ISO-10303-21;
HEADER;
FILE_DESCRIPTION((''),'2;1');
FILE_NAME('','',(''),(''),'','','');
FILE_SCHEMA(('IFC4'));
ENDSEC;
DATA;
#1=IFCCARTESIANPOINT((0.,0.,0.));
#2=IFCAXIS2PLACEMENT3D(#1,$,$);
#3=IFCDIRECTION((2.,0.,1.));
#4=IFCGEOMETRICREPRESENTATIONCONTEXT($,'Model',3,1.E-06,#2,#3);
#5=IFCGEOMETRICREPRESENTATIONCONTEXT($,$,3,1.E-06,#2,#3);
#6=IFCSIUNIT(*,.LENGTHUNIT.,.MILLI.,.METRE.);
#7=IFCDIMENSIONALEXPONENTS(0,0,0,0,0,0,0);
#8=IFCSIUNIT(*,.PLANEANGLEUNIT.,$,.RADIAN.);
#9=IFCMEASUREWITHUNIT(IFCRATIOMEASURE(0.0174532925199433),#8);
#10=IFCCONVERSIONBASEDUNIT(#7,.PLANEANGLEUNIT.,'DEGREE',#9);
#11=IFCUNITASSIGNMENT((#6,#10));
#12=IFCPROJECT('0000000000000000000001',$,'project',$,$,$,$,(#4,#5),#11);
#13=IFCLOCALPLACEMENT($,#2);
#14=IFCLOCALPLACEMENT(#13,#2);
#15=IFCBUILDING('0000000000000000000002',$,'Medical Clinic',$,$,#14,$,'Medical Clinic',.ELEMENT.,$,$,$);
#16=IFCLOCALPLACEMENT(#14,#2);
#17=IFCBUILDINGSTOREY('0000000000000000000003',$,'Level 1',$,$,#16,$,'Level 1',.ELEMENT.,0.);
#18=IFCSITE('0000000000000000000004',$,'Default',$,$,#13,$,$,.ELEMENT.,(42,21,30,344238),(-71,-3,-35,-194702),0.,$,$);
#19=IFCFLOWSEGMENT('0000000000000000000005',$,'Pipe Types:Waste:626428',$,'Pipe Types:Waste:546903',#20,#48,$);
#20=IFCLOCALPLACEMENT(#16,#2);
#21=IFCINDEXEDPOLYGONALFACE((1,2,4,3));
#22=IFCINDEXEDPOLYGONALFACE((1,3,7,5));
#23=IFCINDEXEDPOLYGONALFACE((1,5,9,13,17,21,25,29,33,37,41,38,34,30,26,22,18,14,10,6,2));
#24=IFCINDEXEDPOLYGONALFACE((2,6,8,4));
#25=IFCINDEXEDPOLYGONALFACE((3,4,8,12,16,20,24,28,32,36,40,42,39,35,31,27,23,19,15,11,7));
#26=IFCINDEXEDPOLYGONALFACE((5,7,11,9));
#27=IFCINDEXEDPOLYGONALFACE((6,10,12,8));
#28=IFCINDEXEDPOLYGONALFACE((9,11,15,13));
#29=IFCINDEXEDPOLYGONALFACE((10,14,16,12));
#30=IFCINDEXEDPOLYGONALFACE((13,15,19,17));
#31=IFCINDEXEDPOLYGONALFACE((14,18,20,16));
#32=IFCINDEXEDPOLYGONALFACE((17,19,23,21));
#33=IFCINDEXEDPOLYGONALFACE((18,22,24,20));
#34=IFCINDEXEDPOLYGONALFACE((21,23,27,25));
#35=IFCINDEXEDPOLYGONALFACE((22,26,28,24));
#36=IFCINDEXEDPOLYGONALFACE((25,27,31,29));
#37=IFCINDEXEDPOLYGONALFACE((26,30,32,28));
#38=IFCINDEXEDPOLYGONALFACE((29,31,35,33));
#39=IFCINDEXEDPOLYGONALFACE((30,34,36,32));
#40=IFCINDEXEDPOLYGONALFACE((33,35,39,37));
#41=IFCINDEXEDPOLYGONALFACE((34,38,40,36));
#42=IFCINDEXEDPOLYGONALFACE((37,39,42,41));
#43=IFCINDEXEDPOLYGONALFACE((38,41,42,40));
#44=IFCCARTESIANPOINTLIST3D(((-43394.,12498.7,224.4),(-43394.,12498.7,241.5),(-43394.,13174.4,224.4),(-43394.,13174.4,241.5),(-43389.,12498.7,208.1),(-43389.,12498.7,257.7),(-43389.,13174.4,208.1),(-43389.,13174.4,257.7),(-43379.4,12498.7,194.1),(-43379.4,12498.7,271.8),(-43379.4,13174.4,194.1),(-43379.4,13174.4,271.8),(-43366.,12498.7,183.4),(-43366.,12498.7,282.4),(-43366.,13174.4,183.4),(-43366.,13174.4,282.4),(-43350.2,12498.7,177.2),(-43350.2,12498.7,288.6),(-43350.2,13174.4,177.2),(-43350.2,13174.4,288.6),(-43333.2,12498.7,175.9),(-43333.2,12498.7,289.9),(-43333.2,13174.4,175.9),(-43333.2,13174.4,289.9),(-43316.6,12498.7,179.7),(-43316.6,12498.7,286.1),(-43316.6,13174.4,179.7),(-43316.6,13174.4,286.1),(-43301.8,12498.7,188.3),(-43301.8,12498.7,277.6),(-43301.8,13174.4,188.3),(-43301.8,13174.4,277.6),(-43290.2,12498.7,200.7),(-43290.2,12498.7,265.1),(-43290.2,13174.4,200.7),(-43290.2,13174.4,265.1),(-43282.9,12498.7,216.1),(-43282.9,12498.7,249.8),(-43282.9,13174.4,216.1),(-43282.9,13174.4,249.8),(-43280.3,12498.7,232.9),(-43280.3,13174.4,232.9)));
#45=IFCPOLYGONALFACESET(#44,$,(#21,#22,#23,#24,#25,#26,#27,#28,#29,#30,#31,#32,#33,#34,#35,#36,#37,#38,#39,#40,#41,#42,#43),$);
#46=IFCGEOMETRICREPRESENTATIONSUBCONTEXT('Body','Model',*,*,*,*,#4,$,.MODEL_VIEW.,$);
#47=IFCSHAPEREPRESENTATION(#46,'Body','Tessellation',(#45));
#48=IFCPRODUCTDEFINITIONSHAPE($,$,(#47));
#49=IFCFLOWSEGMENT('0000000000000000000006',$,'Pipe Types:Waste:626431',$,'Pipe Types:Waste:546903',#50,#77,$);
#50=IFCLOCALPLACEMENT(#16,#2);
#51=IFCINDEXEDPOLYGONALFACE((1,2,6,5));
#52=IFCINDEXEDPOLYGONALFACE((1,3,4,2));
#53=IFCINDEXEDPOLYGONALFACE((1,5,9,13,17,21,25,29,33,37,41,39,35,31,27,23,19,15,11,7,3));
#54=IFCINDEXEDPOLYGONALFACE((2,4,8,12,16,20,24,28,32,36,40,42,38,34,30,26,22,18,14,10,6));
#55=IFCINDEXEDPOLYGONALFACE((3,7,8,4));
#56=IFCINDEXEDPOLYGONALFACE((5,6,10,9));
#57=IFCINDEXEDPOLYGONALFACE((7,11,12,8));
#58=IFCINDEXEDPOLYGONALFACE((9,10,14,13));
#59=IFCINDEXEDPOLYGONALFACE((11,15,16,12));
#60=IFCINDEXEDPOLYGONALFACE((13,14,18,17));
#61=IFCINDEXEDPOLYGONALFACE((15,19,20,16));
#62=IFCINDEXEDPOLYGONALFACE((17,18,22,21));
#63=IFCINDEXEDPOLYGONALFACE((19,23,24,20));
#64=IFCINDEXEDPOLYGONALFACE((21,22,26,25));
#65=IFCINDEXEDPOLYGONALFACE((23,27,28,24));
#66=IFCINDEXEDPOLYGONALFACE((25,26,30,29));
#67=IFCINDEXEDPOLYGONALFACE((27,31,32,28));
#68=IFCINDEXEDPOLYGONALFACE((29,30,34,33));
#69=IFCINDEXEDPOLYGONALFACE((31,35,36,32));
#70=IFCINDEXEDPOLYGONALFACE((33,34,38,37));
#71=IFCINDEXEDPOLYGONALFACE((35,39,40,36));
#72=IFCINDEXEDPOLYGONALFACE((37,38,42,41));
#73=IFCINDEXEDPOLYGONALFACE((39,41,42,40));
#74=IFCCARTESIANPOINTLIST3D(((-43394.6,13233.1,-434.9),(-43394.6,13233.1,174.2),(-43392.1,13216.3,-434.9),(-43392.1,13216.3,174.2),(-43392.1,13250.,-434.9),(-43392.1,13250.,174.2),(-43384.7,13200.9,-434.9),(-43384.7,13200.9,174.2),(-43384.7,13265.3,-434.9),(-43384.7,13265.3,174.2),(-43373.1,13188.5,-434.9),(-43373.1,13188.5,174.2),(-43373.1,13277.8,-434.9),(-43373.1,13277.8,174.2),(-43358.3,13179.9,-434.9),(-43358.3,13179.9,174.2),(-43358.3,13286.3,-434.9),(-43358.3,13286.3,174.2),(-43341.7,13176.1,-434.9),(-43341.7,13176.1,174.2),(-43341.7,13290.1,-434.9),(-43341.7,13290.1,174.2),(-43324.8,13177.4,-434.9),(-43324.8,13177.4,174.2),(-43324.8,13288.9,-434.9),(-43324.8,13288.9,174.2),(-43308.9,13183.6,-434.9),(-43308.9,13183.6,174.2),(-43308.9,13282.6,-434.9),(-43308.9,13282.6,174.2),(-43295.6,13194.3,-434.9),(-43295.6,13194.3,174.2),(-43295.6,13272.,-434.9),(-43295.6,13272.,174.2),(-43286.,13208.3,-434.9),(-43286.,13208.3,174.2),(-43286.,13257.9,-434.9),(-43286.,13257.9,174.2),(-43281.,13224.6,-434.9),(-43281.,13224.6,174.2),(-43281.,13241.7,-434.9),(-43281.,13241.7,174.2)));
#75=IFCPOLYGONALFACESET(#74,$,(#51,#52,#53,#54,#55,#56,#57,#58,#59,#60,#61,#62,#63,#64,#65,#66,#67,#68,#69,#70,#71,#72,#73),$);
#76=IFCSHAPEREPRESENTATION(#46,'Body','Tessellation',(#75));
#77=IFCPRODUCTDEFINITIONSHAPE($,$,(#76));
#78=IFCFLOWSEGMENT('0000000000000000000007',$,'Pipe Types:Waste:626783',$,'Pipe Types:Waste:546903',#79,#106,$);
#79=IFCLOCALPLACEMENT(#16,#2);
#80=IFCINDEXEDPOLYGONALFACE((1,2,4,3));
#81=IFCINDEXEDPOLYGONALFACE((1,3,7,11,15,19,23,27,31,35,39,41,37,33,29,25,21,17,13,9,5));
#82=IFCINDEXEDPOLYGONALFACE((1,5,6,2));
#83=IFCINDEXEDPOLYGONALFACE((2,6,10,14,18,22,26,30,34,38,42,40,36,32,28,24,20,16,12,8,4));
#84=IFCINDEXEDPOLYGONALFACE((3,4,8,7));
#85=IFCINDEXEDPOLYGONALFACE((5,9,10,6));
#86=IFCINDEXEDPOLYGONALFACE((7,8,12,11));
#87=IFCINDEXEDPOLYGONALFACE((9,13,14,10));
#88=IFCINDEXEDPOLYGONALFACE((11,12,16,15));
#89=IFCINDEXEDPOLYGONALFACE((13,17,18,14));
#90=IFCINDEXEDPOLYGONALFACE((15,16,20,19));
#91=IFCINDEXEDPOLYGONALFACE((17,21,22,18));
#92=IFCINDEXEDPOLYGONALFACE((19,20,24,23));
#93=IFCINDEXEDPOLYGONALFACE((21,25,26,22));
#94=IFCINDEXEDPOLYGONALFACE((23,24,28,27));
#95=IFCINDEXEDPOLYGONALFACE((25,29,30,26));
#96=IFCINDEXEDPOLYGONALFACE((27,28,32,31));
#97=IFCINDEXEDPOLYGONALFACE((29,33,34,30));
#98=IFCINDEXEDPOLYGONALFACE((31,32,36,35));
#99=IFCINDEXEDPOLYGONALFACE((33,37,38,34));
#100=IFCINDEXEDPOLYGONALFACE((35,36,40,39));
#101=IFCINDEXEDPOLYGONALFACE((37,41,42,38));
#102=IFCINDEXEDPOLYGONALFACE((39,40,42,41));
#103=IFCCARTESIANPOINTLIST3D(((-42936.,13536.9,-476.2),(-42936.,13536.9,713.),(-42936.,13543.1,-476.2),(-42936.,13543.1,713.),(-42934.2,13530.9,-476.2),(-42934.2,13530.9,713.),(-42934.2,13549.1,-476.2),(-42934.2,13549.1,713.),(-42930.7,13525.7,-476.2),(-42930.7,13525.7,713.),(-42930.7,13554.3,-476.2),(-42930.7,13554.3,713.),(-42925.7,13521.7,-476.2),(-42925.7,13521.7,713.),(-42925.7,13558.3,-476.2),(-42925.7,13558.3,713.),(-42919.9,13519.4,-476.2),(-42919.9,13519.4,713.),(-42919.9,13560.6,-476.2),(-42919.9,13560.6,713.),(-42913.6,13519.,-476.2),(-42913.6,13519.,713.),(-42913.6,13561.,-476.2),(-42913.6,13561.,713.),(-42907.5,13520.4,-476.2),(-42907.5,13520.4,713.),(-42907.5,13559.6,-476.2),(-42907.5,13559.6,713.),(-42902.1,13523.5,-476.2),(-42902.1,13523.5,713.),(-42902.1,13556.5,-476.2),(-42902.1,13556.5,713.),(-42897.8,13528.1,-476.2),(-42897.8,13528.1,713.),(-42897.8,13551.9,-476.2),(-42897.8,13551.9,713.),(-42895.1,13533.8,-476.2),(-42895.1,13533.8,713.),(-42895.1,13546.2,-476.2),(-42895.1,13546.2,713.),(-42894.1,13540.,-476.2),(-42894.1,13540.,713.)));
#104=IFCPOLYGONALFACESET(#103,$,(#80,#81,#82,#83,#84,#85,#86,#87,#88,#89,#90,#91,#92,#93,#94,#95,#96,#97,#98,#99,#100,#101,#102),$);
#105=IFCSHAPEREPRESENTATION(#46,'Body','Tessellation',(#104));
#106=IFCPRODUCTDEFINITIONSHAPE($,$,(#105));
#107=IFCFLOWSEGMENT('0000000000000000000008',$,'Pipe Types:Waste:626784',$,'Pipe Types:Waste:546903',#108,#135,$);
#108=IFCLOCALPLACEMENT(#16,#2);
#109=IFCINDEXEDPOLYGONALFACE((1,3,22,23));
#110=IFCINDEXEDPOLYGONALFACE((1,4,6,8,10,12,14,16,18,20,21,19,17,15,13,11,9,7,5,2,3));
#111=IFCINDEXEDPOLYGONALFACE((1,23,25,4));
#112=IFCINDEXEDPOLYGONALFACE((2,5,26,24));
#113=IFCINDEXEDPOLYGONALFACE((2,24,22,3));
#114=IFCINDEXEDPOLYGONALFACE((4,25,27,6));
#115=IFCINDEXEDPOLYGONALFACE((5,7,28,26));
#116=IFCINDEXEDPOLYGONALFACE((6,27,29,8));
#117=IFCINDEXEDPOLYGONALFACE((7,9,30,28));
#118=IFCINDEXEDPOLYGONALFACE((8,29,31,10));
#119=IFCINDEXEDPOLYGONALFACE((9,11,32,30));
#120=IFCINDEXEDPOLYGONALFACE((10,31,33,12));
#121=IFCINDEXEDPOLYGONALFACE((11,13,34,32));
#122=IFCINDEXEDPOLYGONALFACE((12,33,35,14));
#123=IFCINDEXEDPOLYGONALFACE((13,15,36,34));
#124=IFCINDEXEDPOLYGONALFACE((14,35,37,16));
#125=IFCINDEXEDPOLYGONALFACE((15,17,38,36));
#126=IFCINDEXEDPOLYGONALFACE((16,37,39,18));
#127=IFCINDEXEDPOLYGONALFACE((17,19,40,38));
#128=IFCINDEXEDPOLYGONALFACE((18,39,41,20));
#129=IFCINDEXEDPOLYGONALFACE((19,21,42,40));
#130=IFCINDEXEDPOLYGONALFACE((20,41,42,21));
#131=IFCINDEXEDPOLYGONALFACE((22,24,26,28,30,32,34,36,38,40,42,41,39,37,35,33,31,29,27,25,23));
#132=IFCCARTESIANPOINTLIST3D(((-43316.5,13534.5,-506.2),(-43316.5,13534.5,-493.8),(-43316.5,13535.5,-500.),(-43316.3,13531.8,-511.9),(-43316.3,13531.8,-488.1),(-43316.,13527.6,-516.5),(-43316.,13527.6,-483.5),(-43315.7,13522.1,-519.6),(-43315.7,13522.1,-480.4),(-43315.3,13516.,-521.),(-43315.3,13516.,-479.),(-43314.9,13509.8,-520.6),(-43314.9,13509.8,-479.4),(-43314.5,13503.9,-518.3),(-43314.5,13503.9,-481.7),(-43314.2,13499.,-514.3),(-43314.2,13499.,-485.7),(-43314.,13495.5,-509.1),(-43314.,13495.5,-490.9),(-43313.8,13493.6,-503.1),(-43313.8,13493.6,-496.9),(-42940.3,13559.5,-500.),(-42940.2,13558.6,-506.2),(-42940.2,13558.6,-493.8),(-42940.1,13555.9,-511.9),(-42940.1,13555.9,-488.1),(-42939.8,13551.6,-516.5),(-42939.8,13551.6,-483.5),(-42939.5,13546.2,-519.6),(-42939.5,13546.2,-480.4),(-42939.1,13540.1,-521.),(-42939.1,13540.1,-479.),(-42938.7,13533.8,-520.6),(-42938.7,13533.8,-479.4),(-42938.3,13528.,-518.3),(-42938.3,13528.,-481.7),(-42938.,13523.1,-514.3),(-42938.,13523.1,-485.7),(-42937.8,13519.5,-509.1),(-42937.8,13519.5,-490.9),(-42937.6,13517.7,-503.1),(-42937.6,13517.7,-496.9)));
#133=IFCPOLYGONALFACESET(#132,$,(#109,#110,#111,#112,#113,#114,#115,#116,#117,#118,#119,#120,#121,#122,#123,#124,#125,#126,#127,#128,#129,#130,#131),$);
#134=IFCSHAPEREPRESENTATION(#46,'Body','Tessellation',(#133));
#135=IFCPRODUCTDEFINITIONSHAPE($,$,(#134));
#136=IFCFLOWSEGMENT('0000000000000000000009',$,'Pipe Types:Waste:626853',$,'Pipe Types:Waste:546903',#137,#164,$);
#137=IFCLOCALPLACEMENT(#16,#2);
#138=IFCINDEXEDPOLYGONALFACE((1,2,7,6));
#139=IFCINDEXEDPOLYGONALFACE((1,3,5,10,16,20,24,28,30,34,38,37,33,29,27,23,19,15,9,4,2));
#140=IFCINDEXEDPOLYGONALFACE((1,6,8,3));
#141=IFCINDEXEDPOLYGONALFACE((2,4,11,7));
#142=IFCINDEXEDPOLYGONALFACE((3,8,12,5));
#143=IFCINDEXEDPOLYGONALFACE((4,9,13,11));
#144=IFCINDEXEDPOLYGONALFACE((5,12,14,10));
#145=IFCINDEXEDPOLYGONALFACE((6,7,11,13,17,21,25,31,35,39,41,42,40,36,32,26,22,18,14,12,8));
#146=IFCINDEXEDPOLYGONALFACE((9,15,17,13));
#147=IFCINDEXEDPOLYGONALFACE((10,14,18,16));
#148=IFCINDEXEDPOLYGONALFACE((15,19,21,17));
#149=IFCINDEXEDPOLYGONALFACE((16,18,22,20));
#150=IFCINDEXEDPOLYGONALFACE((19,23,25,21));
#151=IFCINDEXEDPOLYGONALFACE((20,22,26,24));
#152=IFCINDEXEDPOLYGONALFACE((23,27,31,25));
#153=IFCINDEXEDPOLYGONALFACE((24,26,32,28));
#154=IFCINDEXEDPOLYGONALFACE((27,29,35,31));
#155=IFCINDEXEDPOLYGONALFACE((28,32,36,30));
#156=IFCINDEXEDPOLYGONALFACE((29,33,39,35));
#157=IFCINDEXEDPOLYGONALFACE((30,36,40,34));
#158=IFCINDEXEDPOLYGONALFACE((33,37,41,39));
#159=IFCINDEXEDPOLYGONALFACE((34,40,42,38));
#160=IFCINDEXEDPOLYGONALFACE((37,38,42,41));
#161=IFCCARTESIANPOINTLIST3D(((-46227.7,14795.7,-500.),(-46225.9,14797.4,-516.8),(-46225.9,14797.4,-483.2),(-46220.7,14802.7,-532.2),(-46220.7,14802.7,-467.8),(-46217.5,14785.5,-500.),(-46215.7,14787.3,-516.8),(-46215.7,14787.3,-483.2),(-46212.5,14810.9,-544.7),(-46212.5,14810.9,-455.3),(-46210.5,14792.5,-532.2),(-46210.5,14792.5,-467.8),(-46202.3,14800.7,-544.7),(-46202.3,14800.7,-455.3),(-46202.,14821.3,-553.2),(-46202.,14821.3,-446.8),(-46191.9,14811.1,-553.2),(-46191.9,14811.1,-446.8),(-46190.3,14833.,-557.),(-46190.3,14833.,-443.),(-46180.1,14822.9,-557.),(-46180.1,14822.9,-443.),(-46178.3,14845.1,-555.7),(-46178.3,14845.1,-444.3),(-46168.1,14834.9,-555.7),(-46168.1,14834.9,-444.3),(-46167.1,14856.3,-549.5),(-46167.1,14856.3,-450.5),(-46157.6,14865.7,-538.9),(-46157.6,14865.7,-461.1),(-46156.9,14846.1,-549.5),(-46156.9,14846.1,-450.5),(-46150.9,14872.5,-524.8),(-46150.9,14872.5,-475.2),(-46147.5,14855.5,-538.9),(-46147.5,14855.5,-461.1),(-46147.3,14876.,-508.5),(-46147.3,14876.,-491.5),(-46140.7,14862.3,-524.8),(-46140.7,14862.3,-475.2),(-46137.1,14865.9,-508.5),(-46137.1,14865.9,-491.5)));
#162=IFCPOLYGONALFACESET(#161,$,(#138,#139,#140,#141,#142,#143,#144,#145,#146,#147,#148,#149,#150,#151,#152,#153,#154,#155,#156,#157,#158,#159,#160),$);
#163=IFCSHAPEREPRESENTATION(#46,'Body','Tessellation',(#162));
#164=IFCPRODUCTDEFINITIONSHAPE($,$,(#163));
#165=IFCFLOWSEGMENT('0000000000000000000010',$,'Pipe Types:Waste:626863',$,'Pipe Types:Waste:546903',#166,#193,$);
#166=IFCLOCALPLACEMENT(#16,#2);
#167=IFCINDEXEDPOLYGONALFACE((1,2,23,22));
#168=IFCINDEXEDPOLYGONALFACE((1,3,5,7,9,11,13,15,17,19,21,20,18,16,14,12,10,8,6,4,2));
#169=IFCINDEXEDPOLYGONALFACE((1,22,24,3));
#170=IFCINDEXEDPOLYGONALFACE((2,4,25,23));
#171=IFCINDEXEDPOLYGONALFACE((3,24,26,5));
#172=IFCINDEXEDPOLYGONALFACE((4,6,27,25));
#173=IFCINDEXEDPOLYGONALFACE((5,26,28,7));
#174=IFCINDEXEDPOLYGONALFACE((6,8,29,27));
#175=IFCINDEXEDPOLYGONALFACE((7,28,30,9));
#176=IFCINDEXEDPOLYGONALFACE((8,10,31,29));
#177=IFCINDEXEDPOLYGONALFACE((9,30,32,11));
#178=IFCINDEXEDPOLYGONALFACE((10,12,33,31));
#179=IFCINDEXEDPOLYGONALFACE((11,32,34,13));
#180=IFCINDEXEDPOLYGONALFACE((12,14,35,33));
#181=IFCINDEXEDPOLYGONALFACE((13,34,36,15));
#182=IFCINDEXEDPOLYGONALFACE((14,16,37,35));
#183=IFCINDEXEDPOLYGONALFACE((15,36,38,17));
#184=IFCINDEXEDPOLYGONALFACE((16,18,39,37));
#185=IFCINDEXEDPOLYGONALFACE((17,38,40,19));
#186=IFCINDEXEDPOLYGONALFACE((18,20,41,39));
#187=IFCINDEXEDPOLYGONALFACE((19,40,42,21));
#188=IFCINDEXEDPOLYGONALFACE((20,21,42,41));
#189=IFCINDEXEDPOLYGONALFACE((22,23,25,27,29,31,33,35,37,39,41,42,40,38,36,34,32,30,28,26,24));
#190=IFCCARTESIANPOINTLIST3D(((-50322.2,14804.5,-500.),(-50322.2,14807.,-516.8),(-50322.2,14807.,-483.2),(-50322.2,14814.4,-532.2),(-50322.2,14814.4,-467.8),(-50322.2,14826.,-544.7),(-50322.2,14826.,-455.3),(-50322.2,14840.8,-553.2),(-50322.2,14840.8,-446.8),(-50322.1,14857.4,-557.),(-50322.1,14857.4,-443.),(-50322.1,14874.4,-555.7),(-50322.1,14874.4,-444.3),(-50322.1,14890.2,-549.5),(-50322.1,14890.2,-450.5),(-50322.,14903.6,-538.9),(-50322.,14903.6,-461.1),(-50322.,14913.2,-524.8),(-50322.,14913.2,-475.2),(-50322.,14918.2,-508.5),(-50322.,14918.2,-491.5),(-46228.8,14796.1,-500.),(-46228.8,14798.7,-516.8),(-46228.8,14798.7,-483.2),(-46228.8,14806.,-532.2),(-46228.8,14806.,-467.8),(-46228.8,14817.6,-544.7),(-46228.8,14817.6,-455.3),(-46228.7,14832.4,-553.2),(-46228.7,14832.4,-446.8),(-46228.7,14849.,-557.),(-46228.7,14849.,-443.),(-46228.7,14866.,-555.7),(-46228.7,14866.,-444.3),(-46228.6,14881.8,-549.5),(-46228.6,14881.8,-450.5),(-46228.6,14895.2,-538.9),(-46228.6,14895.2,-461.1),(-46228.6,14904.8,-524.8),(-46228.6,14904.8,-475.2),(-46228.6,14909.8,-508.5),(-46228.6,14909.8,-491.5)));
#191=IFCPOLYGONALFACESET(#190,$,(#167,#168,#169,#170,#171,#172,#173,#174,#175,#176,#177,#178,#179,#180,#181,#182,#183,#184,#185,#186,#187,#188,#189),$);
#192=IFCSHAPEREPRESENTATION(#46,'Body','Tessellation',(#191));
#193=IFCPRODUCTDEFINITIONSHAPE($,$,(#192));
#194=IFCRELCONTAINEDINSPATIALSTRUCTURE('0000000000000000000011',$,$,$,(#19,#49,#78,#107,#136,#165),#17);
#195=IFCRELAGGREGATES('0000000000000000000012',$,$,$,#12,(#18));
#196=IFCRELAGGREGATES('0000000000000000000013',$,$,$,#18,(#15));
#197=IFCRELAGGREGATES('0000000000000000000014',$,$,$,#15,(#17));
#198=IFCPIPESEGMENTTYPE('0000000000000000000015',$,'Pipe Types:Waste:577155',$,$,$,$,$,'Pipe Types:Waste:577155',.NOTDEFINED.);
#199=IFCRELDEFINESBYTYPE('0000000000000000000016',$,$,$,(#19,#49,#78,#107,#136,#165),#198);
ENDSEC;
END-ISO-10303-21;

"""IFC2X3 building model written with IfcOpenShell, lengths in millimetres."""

from ifc_helpers import new_model, entity, si_unit, converted_unit, direction, frame, frame_2d, origin, origin_2d_with_axis, place, context, subcontext, project, spatial, circle, extrude, type_object, element, save


model = new_model("IFC2X3")

# Units and contexts
model_context = context("Model", 3, precision=1e-06, world=origin(), true_north=direction((2.0, 0.0, 1.0)))
context_of_model = context(None, 3, precision=1e-06, world=origin(), true_north=direction((2.0, 0.0, 1.0)))
body_context = subcontext(model_context, "Body", "Model", "MODEL_VIEW")
ifc_project = project(units=[si_unit("LENGTHUNIT", "METRE", prefix="MILLI"), converted_unit("PLANEANGLEUNIT", "DEGREE", entity("IfcRatioMeasure", 0.0174532925199433), si_unit("PLANEANGLEUNIT", "RADIAN"), dimensions=[0, 0, 0, 0, 0, 0, 0])], contexts=[model_context, context_of_model])

# Site, building, storey
site_placement = place(None, origin())
site = spatial("IfcSite", under=ifc_project, at=site_placement, Name="Default", CompositionType="ELEMENT", RefLatitude=(42, 21, 30, 344238), RefLongitude=(-71, -3, -35, -194702), RefElevation=0.0)
building_placement = place(site_placement, origin())
building = spatial("IfcBuilding", under=site, at=building_placement, Name="Medical Clinic", LongName="Medical Clinic", CompositionType="ELEMENT")
storey_placement = place(building_placement, origin())
storey = spatial("IfcBuildingStorey", under=building, at=storey_placement, Name="Level 1", LongName="Level 1", CompositionType="ELEMENT", Elevation=0.0)

# Flow segments
pipe_segment_type = type_object("IfcPipeSegmentType", Name="Pipe Types:Waste:577155", ElementType="Pipe Types:Waste:577155", PredefinedType="NOTDEFINED")
flow_segment_1_placement = place(storey_placement, origin())
element("IfcFlowSegment", 1, at=flow_segment_1_placement, inside=storey, type_object=pipe_segment_type, Name="Pipe Types:Waste:626428", ObjectType="Pipe Types:Waste:546903", context=body_context, shape_type="SweptSolid", body=[
    extrude(circle(Radius=57.1, at=frame_2d((0.0, 0.0), x_axis=(1.0, 0.0))), frame((-43337.5, 12498.7, 232.9), z_axis=(0.0, 1.0, 0.0), x_axis=(1.0, 0.0, 0.0)), (0.0, 0.0, 1.0), 675.7),
])
flow_segment_2_placement = place(storey_placement, origin())
element("IfcFlowSegment", 2, at=flow_segment_2_placement, inside=storey, type_object=pipe_segment_type, Name="Pipe Types:Waste:626431", ObjectType="Pipe Types:Waste:546903", context=body_context, shape_type="SweptSolid", body=[
    extrude(circle(Radius=57.1, at=origin_2d_with_axis()), frame((-43337.5, 13233.1, -434.9), z_axis=(0.0, 0.0, 1.0), x_axis=(-1.0, 0.0, 0.0)), (0.0, 0.0, 1.0), 609.1),
])
flow_segment_3_placement = place(storey_placement, origin())
element("IfcFlowSegment", 3, at=flow_segment_3_placement, inside=storey, type_object=pipe_segment_type, Name="Pipe Types:Waste:626783", ObjectType="Pipe Types:Waste:546903", context=body_context, shape_type="SweptSolid", body=[
    extrude(circle(Radius=21.1, at=frame_2d((0.0, 0.0), x_axis=(1.0, 0.0))), frame((-42915.2, 13540.0, -476.2)), (0.0, 0.0, 1.0), 1189.2),
])
flow_segment_4_placement = place(storey_placement, origin())
element("IfcFlowSegment", 4, at=flow_segment_4_placement, inside=storey, type_object=pipe_segment_type, Name="Pipe Types:Waste:626784", ObjectType="Pipe Types:Waste:546903", context=body_context, shape_type="SweptSolid", body=[
    extrude(circle(Radius=21.1, at=frame_2d((0.0, 0.0), x_axis=(1.0, 0.0))), frame((-43315.2, 13514.4, -500.0), z_axis=(0.997964, 0.063781, 0.0), x_axis=(-0.063781, 0.997964, 0.0)), (0.0, 0.0, 1.0), 377.0),
])
flow_segment_5_placement = place(storey_placement, origin())
element("IfcFlowSegment", 5, at=flow_segment_5_placement, inside=storey, type_object=pipe_segment_type, Name="Pipe Types:Waste:626853", ObjectType="Pipe Types:Waste:546903", context=body_context, shape_type="SweptSolid", body=[
    extrude(circle(Radius=57.1, at=frame_2d((0.0, 0.0), x_axis=(1.0, 0.0))), frame((-46177.1, 14825.9, -500.0), z_axis=(-0.707107, 0.707107, 0.0), x_axis=(-0.707107, -0.707107, 0.0)), (0.0, 0.0, 1.0), 14.4),
])
flow_segment_6_placement = place(storey_placement, origin())
element("IfcFlowSegment", 6, at=flow_segment_6_placement, inside=storey, type_object=pipe_segment_type, Name="Pipe Types:Waste:626863", ObjectType="Pipe Types:Waste:546903", context=body_context, shape_type="SweptSolid", body=[
    extrude(circle(Radius=57.1, at=frame_2d((0.0, 0.0), x_axis=(1.0, 0.0))), frame((-46228.7, 14853.3, -500.0), z_axis=(-0.999998, 0.00205, 0.0), x_axis=(-0.00205, -0.999998, 0.0)), (0.0, 0.0, 1.0), 4093.4),
])

save(model, "model.ifc")
